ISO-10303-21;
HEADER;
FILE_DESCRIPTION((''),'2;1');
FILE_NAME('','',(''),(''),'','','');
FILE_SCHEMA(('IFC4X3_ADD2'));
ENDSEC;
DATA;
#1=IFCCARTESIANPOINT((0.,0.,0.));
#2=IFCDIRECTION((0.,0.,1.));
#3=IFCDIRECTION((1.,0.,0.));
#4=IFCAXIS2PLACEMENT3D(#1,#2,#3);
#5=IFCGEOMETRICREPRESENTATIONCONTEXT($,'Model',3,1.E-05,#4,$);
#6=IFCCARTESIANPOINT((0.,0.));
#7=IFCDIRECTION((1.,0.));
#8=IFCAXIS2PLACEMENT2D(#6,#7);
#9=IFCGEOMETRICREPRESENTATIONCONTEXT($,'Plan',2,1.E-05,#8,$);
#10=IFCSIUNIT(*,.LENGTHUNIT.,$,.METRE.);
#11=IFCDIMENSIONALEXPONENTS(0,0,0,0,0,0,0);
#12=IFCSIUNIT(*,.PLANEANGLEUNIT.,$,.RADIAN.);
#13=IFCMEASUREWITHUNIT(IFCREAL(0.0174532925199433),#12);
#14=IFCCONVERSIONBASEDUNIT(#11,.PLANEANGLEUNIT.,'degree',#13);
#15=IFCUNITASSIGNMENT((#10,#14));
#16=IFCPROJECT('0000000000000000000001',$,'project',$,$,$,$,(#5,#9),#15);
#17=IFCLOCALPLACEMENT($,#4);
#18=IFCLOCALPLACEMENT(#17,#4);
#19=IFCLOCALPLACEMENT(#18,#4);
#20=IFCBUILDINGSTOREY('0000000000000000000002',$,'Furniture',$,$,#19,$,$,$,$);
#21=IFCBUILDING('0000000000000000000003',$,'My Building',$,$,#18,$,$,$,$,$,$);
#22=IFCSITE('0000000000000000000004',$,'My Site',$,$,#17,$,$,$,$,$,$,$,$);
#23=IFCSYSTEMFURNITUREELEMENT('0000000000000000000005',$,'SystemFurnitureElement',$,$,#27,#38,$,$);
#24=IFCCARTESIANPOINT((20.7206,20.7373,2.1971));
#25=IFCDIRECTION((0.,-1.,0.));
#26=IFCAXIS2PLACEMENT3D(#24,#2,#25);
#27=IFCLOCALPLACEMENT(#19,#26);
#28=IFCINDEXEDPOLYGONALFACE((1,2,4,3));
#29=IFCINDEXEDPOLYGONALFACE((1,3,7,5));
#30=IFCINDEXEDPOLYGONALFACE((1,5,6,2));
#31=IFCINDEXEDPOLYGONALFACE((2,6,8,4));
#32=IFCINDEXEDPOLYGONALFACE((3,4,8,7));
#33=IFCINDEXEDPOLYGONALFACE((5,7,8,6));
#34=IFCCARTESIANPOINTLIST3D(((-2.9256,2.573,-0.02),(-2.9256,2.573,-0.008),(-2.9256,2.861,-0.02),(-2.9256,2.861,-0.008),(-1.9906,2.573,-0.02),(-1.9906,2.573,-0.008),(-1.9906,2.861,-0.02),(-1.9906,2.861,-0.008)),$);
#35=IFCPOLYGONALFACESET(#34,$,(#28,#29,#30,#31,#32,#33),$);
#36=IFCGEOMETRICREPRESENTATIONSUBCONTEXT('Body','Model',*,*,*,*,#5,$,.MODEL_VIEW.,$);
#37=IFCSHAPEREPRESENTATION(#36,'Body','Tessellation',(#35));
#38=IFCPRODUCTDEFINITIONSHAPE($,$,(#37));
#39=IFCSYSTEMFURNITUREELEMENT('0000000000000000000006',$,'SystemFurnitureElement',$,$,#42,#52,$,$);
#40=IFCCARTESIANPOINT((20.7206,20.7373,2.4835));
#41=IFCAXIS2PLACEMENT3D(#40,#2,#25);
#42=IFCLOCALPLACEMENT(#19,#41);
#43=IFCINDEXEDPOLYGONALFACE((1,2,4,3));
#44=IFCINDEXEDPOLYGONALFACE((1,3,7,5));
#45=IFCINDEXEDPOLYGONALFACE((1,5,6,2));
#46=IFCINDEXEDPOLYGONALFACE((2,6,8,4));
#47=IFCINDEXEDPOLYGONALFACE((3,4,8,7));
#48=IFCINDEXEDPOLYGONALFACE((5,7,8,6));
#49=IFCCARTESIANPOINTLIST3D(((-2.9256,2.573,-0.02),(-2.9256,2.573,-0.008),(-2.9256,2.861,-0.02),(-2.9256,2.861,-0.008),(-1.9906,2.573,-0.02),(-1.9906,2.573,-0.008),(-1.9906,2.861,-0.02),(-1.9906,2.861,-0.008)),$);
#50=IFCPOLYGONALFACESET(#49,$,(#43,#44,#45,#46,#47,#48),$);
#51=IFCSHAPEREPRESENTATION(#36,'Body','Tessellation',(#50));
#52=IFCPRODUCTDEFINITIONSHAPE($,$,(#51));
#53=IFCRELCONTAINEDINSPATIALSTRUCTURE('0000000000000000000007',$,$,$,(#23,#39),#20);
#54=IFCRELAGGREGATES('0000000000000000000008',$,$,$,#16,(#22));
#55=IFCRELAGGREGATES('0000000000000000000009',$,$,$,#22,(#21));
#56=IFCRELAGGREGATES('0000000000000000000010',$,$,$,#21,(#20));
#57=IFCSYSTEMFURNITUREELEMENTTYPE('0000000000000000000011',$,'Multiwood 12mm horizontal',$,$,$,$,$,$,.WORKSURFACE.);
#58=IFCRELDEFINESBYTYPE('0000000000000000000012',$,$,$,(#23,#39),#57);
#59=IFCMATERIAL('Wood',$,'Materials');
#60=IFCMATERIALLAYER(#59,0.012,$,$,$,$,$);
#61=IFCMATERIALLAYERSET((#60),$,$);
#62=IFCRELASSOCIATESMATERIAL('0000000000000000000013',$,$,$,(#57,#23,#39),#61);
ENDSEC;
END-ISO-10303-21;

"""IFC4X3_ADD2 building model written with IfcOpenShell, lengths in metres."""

from ifc_helpers import new_model, entity, si_unit, converted_unit, frame, origin_with_axes, origin_2d_with_axis, place, context, subcontext, project, spatial, indexed_curve, outline, extrude, material, layer, layer_set, layer_usage, type_object, element, save


model = new_model("IFC4X3_ADD2")

# Units and contexts
model_context = context("Model", 3, precision=1e-05, world=origin_with_axes())
plan_context = context("Plan", 2, precision=1e-05, world=origin_2d_with_axis())
body_context = subcontext(model_context, "Body", "Model", "MODEL_VIEW")
ifc_project = project(units=[si_unit("LENGTHUNIT", "METRE"), converted_unit("PLANEANGLEUNIT", "degree", entity("IfcReal", 0.0174532925199433), si_unit("PLANEANGLEUNIT", "RADIAN"), dimensions=[0, 0, 0, 0, 0, 0, 0])], contexts=[model_context, plan_context])

# Site, building, storey
site_placement = place(None, origin_with_axes())
site = spatial("IfcSite", under=ifc_project, at=site_placement, Name="My Site")
building_placement = place(site_placement, origin_with_axes())
building = spatial("IfcBuilding", under=site, at=building_placement, Name="My Building")
storey_placement = place(building_placement, origin_with_axes())
storey = spatial("IfcBuildingStorey", under=building, at=storey_placement, Name="Furniture")

# System furniture elements
ifc_material = material(Name="Wood", Category="Materials")
ifc_layer_1 = layer(ifc_material, 0.012)
ifc_layer_set_1 = layer_set([ifc_layer_1])
system_furniture_element_type_1 = type_object("IfcSystemFurnitureElementType", Name="Multiwood 12mm horizontal", PredefinedType="WORKSURFACE", material=ifc_layer_set_1)
ifc_layer_usage_1 = layer_usage(ifc_layer_set_1, "AXIS3", "POSITIVE", -0.02)
system_furniture_element_1_placement = place(storey_placement, frame((20.7206, 20.7373, 2.1971), z_axis=(0.0, 0.0, 1.0), x_axis=(0.0, -1.0, 0.0)))
element("IfcSystemFurnitureElement", 1, at=system_furniture_element_1_placement, inside=storey, type_object=system_furniture_element_type_1, material=ifc_layer_usage_1, Name="SystemFurnitureElement", context=body_context, shape_type="SweptSolid", body=[
    extrude(outline(indexed_curve([(-2.9256, 2.861), (-2.9256, 2.573), (-1.9906, 2.573), (-1.9906, 2.861), (-2.9256, 2.861)])), frame((0.0, 0.0, -0.02), z_axis=(0.0, 0.0, 1.0), x_axis=(1.0, 0.0, 0.0)), (0.0, 0.0, 1.0), 0.012),
])
ifc_layer_usage_2 = layer_usage(ifc_layer_set_1, "AXIS3", "POSITIVE", -0.02)
system_furniture_element_2_placement = place(storey_placement, frame((20.7206, 20.7373, 2.4835), z_axis=(0.0, 0.0, 1.0), x_axis=(0.0, -1.0, 0.0)))
element("IfcSystemFurnitureElement", 2, at=system_furniture_element_2_placement, inside=storey, type_object=system_furniture_element_type_1, material=ifc_layer_usage_2, Name="SystemFurnitureElement", context=body_context, shape_type="SweptSolid", body=[
    extrude(outline(indexed_curve([(-2.9256, 2.861), (-2.9256, 2.573), (-1.9906, 2.573), (-1.9906, 2.861), (-2.9256, 2.861)])), frame((0.0, 0.0, -0.02), z_axis=(0.0, 0.0, 1.0), x_axis=(1.0, 0.0, 0.0)), (0.0, 0.0, 1.0), 0.012),
])

save(model, "model.ifc")
